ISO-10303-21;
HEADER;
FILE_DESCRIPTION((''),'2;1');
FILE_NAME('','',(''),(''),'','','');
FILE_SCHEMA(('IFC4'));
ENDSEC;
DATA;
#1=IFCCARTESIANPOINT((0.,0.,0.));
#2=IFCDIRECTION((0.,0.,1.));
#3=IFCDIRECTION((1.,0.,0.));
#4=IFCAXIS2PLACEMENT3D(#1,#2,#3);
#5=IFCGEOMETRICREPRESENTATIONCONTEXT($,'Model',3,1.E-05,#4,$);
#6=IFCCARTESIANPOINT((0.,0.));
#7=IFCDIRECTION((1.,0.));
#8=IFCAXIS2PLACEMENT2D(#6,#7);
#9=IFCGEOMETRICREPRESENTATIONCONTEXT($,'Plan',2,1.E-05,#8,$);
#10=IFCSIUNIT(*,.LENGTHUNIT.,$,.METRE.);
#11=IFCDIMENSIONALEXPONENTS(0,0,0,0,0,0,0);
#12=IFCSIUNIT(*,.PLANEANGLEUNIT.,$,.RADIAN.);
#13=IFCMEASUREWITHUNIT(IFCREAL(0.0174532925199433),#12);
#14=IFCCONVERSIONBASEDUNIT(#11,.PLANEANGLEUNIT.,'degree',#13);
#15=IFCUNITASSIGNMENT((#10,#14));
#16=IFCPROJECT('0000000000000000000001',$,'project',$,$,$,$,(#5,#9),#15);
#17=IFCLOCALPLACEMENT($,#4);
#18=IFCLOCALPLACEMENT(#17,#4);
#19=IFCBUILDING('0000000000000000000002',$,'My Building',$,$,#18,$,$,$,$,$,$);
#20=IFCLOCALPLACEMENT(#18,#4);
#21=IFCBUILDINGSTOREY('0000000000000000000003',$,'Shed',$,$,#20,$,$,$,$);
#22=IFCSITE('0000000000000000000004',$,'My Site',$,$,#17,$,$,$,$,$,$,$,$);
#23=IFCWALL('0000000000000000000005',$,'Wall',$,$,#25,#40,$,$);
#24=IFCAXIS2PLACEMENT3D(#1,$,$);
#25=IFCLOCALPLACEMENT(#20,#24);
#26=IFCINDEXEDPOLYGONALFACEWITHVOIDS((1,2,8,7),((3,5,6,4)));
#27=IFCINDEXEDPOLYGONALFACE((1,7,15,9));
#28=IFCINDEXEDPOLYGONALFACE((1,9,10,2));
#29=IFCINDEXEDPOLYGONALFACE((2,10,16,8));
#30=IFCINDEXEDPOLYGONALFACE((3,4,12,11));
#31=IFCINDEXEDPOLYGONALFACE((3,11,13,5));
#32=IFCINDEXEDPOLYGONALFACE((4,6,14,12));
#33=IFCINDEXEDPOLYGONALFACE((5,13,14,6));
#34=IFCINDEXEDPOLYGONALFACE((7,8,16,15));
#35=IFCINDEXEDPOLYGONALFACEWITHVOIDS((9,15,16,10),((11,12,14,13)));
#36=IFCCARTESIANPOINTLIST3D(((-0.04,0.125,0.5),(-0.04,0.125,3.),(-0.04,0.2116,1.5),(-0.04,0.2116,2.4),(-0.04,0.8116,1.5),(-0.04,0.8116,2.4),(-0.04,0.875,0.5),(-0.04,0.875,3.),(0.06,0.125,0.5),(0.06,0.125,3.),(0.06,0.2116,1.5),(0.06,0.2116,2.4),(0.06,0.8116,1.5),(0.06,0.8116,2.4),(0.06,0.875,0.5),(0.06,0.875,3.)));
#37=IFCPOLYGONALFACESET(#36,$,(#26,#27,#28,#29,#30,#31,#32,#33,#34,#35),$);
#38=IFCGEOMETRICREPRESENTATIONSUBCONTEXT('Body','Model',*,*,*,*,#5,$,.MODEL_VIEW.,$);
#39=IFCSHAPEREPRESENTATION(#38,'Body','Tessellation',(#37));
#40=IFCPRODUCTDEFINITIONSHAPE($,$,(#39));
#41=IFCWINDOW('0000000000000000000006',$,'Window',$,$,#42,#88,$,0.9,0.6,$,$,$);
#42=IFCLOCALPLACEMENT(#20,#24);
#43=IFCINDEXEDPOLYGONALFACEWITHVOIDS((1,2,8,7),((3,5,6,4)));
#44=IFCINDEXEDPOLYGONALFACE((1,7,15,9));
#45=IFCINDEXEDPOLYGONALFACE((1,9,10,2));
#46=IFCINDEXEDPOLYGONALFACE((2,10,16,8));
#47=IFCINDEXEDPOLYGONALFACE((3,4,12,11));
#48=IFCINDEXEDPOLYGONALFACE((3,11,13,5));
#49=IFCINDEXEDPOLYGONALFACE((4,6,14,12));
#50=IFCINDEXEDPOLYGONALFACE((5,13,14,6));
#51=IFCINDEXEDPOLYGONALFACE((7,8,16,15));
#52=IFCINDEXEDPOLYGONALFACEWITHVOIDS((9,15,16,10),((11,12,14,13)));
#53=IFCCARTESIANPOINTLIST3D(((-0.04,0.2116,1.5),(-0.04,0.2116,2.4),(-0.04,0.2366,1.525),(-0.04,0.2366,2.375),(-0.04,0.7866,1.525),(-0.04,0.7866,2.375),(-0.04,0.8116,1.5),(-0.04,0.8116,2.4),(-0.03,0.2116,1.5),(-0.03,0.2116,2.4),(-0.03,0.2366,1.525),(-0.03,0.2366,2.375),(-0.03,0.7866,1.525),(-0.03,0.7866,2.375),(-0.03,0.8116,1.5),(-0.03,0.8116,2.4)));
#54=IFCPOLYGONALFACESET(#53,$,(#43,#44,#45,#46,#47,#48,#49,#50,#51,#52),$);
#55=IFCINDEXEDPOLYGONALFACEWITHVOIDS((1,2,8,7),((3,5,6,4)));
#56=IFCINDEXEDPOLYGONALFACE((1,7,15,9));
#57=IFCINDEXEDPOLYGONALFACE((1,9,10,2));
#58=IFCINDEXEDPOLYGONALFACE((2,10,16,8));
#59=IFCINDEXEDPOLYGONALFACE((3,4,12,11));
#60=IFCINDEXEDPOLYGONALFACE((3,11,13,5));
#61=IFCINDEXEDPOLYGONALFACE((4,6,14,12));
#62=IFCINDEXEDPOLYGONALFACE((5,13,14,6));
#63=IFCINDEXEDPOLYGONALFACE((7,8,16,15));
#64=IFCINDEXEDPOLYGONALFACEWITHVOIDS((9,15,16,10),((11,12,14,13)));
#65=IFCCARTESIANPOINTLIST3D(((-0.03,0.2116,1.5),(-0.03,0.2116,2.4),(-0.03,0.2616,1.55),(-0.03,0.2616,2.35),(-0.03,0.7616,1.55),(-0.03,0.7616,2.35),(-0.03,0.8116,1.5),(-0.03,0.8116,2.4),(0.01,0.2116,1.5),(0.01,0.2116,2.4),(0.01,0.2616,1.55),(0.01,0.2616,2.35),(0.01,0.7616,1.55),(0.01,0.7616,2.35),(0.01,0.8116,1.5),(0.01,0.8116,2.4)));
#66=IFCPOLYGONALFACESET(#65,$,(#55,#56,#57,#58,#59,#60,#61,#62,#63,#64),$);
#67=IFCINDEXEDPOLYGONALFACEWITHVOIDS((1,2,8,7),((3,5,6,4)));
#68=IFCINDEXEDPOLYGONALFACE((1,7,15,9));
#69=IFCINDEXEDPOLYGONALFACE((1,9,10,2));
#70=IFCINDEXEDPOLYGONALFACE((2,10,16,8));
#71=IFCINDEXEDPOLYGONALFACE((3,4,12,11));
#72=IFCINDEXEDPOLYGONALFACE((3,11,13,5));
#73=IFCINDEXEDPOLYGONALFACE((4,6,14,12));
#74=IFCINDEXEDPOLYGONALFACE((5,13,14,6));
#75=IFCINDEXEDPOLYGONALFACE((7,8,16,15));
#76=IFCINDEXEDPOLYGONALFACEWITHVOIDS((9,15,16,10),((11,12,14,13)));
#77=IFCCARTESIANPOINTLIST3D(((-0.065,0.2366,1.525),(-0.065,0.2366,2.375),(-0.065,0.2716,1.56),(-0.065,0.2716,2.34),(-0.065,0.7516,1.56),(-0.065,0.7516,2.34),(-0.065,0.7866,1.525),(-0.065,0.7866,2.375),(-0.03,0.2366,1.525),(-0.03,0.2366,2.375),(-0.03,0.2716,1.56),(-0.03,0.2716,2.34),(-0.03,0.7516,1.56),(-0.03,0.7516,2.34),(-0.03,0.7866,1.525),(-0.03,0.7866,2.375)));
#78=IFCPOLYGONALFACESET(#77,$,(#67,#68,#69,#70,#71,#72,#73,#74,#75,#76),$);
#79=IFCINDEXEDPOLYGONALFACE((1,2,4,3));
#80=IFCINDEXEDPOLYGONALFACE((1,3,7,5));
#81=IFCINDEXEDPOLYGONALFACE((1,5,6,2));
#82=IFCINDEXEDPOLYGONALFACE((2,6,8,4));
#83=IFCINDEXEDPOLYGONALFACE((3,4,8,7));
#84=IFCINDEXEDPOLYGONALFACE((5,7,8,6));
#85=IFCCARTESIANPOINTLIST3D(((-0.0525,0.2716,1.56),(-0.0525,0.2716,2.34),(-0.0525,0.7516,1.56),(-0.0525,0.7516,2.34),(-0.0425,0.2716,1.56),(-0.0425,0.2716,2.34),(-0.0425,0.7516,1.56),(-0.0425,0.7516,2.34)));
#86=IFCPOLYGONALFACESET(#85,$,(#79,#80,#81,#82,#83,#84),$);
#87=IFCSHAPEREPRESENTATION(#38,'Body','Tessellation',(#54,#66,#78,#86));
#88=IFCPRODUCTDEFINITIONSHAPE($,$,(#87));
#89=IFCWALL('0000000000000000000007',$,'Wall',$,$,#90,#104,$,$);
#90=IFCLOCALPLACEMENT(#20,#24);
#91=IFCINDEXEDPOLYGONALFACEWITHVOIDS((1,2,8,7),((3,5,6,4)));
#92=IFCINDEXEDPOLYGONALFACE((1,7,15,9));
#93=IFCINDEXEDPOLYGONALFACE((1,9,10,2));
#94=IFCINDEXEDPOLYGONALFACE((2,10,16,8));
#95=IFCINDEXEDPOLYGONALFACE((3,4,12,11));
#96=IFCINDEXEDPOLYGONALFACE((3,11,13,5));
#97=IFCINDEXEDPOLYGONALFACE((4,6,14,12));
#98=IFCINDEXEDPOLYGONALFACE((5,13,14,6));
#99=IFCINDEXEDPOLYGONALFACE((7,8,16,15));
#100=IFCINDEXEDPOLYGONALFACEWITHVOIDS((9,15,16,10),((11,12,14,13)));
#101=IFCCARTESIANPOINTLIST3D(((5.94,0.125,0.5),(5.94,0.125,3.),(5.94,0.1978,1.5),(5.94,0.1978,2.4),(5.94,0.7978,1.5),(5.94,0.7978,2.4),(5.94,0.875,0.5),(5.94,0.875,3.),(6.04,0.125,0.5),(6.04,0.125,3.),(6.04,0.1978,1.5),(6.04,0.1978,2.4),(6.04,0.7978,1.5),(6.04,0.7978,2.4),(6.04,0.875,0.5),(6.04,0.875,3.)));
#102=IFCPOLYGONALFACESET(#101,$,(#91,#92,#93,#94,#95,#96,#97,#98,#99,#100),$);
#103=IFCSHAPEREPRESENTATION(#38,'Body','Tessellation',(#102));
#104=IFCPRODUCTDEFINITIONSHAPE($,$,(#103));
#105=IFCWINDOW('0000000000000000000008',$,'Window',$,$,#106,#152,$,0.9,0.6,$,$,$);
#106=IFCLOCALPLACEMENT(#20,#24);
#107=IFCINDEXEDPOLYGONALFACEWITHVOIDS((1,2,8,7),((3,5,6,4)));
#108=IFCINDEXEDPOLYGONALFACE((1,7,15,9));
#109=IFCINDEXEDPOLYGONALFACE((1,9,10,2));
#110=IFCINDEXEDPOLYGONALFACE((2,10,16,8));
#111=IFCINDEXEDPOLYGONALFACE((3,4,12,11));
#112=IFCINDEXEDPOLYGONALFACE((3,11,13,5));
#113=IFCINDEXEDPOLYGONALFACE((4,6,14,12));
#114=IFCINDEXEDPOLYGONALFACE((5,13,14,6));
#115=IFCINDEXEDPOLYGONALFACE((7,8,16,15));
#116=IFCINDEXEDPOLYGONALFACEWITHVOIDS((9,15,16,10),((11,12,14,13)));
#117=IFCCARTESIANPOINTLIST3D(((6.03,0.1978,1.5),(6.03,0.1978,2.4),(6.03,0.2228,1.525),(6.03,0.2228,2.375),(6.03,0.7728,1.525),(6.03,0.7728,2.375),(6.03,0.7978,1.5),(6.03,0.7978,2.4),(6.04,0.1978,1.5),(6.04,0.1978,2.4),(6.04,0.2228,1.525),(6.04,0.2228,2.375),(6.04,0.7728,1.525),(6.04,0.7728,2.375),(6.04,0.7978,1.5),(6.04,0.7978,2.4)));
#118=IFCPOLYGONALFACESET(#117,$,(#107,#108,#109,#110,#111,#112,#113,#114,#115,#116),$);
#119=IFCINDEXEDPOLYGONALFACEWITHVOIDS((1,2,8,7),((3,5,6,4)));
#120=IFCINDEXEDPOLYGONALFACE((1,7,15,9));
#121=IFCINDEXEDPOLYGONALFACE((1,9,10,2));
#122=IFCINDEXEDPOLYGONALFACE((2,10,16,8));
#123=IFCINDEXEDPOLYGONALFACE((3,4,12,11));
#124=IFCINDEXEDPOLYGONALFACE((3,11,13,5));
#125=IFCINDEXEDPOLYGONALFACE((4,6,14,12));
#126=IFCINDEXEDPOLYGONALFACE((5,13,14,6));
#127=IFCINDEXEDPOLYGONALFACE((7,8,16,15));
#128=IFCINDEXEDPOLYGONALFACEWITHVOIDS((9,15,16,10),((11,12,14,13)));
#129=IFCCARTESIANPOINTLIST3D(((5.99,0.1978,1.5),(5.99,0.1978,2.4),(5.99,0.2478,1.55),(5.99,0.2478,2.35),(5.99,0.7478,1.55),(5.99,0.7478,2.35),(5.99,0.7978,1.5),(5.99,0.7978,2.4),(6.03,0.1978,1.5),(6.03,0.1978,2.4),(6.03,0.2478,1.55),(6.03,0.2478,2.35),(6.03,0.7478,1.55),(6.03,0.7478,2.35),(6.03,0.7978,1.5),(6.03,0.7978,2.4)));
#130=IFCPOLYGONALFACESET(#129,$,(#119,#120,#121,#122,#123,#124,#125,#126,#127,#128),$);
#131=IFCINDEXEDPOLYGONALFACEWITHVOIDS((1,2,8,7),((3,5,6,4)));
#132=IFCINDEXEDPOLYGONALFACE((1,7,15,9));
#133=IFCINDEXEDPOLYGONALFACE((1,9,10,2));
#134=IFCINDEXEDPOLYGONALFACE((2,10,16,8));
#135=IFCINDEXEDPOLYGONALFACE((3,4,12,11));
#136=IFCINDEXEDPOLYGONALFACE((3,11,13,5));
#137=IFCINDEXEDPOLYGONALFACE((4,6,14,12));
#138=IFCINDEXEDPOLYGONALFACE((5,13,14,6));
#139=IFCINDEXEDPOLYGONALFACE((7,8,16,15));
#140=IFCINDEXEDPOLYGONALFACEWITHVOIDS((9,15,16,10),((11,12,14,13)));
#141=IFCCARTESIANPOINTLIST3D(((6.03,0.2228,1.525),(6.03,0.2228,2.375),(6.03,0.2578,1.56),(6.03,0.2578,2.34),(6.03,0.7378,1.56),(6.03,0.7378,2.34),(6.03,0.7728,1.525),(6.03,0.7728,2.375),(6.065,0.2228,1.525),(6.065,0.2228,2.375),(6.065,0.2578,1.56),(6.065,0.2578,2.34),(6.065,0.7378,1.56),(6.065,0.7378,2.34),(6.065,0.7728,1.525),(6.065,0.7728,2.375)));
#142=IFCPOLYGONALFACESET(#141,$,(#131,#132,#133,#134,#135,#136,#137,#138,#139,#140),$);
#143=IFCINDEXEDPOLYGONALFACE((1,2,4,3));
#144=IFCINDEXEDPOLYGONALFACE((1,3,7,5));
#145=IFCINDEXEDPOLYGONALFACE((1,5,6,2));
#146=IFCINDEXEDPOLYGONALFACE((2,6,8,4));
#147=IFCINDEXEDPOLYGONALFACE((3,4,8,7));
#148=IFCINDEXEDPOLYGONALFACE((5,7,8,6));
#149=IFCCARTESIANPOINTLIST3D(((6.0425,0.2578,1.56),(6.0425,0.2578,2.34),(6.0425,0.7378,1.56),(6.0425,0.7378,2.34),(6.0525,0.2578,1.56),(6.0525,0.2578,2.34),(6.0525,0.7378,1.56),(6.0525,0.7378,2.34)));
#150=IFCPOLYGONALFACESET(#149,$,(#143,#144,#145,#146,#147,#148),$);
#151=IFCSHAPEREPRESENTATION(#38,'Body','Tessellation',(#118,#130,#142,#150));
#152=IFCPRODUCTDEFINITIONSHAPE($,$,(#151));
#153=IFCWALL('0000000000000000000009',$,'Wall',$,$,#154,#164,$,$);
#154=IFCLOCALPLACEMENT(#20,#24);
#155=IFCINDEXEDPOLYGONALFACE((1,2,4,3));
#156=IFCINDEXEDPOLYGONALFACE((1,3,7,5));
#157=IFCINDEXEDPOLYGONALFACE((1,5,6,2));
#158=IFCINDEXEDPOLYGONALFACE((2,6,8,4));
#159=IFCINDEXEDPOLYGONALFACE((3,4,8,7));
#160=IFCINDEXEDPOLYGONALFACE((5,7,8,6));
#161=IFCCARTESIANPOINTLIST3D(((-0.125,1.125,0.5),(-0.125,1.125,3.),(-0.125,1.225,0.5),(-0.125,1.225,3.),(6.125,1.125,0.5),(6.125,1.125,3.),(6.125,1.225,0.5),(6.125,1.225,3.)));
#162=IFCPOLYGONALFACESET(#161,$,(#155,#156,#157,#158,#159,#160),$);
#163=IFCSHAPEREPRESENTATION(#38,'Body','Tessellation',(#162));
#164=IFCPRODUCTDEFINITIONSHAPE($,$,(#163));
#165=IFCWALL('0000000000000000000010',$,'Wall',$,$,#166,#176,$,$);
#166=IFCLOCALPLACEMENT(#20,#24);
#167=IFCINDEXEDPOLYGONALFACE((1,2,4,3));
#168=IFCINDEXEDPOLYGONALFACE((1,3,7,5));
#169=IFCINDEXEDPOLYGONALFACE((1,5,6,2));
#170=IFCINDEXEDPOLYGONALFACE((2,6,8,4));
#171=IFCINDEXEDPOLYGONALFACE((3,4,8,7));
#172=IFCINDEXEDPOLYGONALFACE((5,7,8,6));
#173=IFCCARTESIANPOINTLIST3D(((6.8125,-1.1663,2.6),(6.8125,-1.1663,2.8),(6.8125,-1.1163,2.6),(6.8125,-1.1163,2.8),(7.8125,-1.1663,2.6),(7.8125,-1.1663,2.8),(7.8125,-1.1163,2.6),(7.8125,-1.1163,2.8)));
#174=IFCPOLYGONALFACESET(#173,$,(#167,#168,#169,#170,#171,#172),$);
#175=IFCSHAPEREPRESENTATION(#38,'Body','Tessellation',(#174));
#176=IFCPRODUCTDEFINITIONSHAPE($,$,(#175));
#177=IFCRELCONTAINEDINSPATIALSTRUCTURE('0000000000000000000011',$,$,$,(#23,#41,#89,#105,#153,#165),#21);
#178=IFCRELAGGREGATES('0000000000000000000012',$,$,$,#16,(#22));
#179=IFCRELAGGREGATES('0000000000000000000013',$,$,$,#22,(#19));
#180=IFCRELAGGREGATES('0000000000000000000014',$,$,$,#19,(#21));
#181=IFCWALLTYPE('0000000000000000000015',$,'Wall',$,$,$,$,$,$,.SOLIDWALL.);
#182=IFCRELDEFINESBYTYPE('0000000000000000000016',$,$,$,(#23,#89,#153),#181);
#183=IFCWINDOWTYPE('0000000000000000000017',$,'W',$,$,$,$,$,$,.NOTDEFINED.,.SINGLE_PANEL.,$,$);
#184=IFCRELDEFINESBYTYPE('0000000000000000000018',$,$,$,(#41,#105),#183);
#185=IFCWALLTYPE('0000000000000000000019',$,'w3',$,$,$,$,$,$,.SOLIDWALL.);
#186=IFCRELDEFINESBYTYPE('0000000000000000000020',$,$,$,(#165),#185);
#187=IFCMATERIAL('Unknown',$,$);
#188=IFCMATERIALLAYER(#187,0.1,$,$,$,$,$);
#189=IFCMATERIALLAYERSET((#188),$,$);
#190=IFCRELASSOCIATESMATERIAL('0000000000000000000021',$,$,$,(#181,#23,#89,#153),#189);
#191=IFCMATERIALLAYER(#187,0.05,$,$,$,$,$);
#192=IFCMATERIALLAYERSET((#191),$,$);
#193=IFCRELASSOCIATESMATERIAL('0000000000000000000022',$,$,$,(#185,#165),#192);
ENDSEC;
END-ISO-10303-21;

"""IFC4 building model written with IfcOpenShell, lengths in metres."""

from ifc_helpers import new_model, entity, si_unit, converted_unit, frame, origin_with_axes, origin_2d_with_axis, place, context, subcontext, project, spatial, line, indexed_curve, outline, extrude, shape, source, transform, mapped, material, layer, layer_set, layer_usage, type_object, type_shapes, element, fill, save


model = new_model("IFC4")

# Units and contexts
model_context = context("Model", 3, precision=1e-05, world=origin_with_axes())
plan_context = context("Plan", 2, precision=1e-05, world=origin_2d_with_axis())
body_context_1 = subcontext(model_context, "Body", "Model", "MODEL_VIEW")
body_context_2 = subcontext(plan_context, "Body", "Plan", "PLAN_VIEW")
ifc_project = project(units=[si_unit("LENGTHUNIT", "METRE"), converted_unit("PLANEANGLEUNIT", "degree", entity("IfcReal", 0.0174532925199433), si_unit("PLANEANGLEUNIT", "RADIAN"), dimensions=[0, 0, 0, 0, 0, 0, 0])], contexts=[model_context, plan_context])

# Site, building, storey
site_placement = place(None, origin_with_axes())
site = spatial("IfcSite", under=ifc_project, at=site_placement, Name="My Site")
building_placement = place(site_placement, origin_with_axes())
building = spatial("IfcBuilding", under=site, at=building_placement, Name="My Building")
storey_placement = place(building_placement, origin_with_axes())
storey = spatial("IfcBuildingStorey", under=building, at=storey_placement, Name="Shed")

# Shared definitions
ifc_material = material(Name="Unknown")

# Walls, openings, windows
ifc_layer_1 = layer(ifc_material, 0.1)
ifc_layer_set_1 = layer_set([ifc_layer_1])
ifc_layer_usage_1 = layer_usage(ifc_layer_set_1, "AXIS2", "POSITIVE", 0.0)
wall_type_1 = type_object("IfcWallType", Name="Wall", PredefinedType="SOLIDWALL", material=ifc_layer_set_1)
wall_1_placement = place(storey_placement, frame((0.06, 0.125, 0.5), z_axis=(0.0, 0.0, 1.0), x_axis=(0.0, 1.0, 0.0)))
wall_1 = element("IfcWall", 1, at=wall_1_placement, inside=storey, type_object=wall_type_1, material=ifc_layer_usage_1, Name="Wall", context=body_context_1, shape_type="SweptSolid", body=[
    extrude(outline(indexed_curve([(0.0, 0.0), (0.0, 0.1), (0.75, 0.1), (0.75, 0.0)], segments=[line(1, 2, 3, 4, 1)])), origin_with_axes(), (0.0, 0.0, 1.0), 2.5),
])
shared_shape_1 = source(origin_with_axes(), body_context_1, "Body", "SweptSolid", [
    extrude(outline(indexed_curve([(0.0, 0.0), (0.6, 0.0), (0.6, 0.9), (0.0, 0.9)], segments=[line(1, 2, 3, 4, 1)])), frame((0.0, -0.6, 0.0), z_axis=(0.0, -1.0, 0.0), x_axis=(1.0, 0.0, 0.0)), (0.0, 0.0, -1.0), 1.2),
])
opening_1_placement = place(wall_1_placement, frame((0.0866, 0.0, 1.0), z_axis=(0.0, 0.0, 1.0), x_axis=(1.0, 0.0, 0.0)))
opening_1 = element("IfcOpeningElement", 2, at=opening_1_placement, cuts=wall_1, PredefinedType="OPENING", context=body_context_1, shape_type="MappedRepresentation", body=[
    mapped(shared_shape_1, transform((0.0, 0.0, 0.0), x_axis=(1.0, 0.0, 0.0), y_axis=(0.0, 1.0, 0.0), z_axis=(0.0, 0.0, 1.0), scale=1.0)),
])
window_type = type_object("IfcWindowType", Name="W", PartitioningType="SINGLE_PANEL", PredefinedType="NOTDEFINED")
shared_shape_2 = source(origin_with_axes(), body_context_1, "Body", "SweptSolid", [
    extrude(outline(indexed_curve([(0.0, 0.0), (0.6, 0.0), (0.6, 0.9), (0.0, 0.9)], segments=[line(1, 2, 3, 4, 1)]), holes=[indexed_curve([(0.025, 0.025), (0.575, 0.025), (0.575, 0.875), (0.025, 0.875)], segments=[line(1, 2, 3, 4, 1)])]), frame((0.0, 0.09, 0.0), z_axis=(0.0, -1.0, 0.0), x_axis=(1.0, 0.0, 0.0)), (0.0, 0.0, -1.0), 0.01),
    extrude(outline(indexed_curve([(0.0, 0.0), (0.6, 0.0), (0.6, 0.9), (0.0, 0.9)], segments=[line(1, 2, 3, 4, 1)]), holes=[indexed_curve([(0.05, 0.05), (0.55, 0.05), (0.55, 0.85), (0.05, 0.85)], segments=[line(1, 2, 3, 4, 1)])]), frame((0.0, 0.05, 0.0), z_axis=(0.0, -1.0, 0.0), x_axis=(1.0, 0.0, 0.0)), (0.0, 0.0, -1.0), 0.04),
    extrude(outline(indexed_curve([(0.0, 0.0), (0.55, 0.0), (0.55, 0.85), (0.0, 0.85)], segments=[line(1, 2, 3, 4, 1)]), holes=[indexed_curve([(0.035, 0.035), (0.515, 0.035), (0.515, 0.815), (0.035, 0.815)], segments=[line(1, 2, 3, 4, 1)])]), frame((0.025, 0.09, 0.025), z_axis=(0.0, -1.0, 0.0), x_axis=(1.0, 0.0, 0.0)), (0.0, 0.0, -1.0), 0.035),
    extrude(outline(indexed_curve([(0.035, 0.035), (0.515, 0.035), (0.515, 0.815), (0.035, 0.815)], segments=[line(1, 2, 3, 4, 1)])), frame((0.025, 0.1025, 0.025), z_axis=(0.0, -1.0, 0.0), x_axis=(1.0, 0.0, 0.0)), (0.0, 0.0, -1.0), 0.01),
])
shared_shape_3 = source(origin_with_axes(), body_context_2, "Body", "Curve2D", [
    entity("IfcIndexedPolyCurve", entity("IfcCartesianPointList2D", [[0.05, 0.05], [0.55, 0.05]])),
    entity("IfcIndexedPolyCurve", entity("IfcCartesianPointList2D", [[0.0, 0.1], [0.025, 0.1], [0.025, 0.09], [0.05, 0.09], [0.05, 0.05], [0.0, 0.05]]), [entity("IfcLineIndex", [1, 2, 3, 4, 5, 6, 1])]),
    entity("IfcIndexedPolyCurve", entity("IfcCartesianPointList2D", [[0.6, 0.1], [0.575, 0.1], [0.575, 0.09], [0.55, 0.09], [0.55, 0.05], [0.6, 0.05]]), [entity("IfcLineIndex", [1, 2, 3, 4, 5, 6, 1])]),
    entity("IfcIndexedPolyCurve", entity("IfcCartesianPointList2D", [[0.025, 0.09], [0.06, 0.09], [0.06, 0.125], [0.025, 0.125]]), [entity("IfcLineIndex", [1, 2, 3, 4, 1])]),
    entity("IfcIndexedPolyCurve", entity("IfcCartesianPointList2D", [[0.575, 0.09], [0.54, 0.09], [0.54, 0.125], [0.575, 0.125]]), [entity("IfcLineIndex", [1, 2, 3, 4, 1])]),
    entity("IfcIndexedPolyCurve", entity("IfcCartesianPointList2D", [[0.06, 0.09], [0.54, 0.09]])),
    entity("IfcIndexedPolyCurve", entity("IfcCartesianPointList2D", [[0.06, 0.125], [0.54, 0.125]])),
    entity("IfcIndexedPolyCurve", entity("IfcCartesianPointList2D", [[0.06, 0.1075], [0.54, 0.1075]])),
])
type_shapes(window_type, [shared_shape_2, shared_shape_3])
window_1_placement = place(opening_1_placement, origin_with_axes())
window_1 = element("IfcWindow", 3, at=window_1_placement, inside=storey, type_object=window_type, Name="Window", OverallHeight=0.9, OverallWidth=0.6, shapes=[
    shape(body_context_1, "Body", "MappedRepresentation", [mapped(shared_shape_2, transform((0.0, 0.0, 0.0), x_axis=(1.0, 0.0, 0.0), y_axis=(0.0, 1.0, 0.0), z_axis=(0.0, 0.0, 1.0), scale=1.0))]),
    shape(body_context_2, "Body", "MappedRepresentation", [mapped(shared_shape_3, transform((0.0, 0.0, 0.0), x_axis=(1.0, 0.0, 0.0), y_axis=(0.0, 1.0, 0.0), z_axis=(0.0, 0.0, 1.0), scale=1.0))]),
])
fill(opening_1, window_1)
ifc_layer_usage_2 = layer_usage(ifc_layer_set_1, "AXIS2", "POSITIVE", 0.0)
wall_2_placement = place(storey_placement, frame((5.94, 0.875, 0.5), z_axis=(0.0, 0.0, 1.0), x_axis=(0.0, -1.0, 0.0)))
wall_2 = element("IfcWall", 4, at=wall_2_placement, inside=storey, type_object=wall_type_1, material=ifc_layer_usage_2, Name="Wall", context=body_context_1, shape_type="SweptSolid", body=[
    extrude(outline(indexed_curve([(0.0, 0.0), (0.0, 0.1), (0.75, 0.1), (0.75, 0.0)], segments=[line(1, 2, 3, 4, 1)])), origin_with_axes(), (0.0, 0.0, 1.0), 2.5),
])
opening_2_placement = place(wall_2_placement, frame((0.0772, 0.0, 1.0), z_axis=(0.0, 0.0, 1.0), x_axis=(1.0, 0.0, 0.0)))
opening_2 = element("IfcOpeningElement", 5, at=opening_2_placement, cuts=wall_2, PredefinedType="OPENING", context=body_context_1, shape_type="MappedRepresentation", body=[
    mapped(shared_shape_1, transform((0.0, 0.0, 0.0), x_axis=(1.0, 0.0, 0.0), y_axis=(0.0, 1.0, 0.0), z_axis=(0.0, 0.0, 1.0), scale=1.0)),
])
window_2_placement = place(opening_2_placement, frame((0.0, 0.0, 0.0), z_axis=(0.0, 0.0, 1.0), x_axis=(1.0, 0.0, 0.0)))
window_2 = element("IfcWindow", 6, at=window_2_placement, inside=storey, type_object=window_type, Name="Window", OverallHeight=0.9, OverallWidth=0.6, shapes=[
    shape(body_context_1, "Body", "MappedRepresentation", [mapped(shared_shape_2, transform((0.0, 0.0, 0.0), x_axis=(1.0, 0.0, 0.0), y_axis=(0.0, 1.0, 0.0), z_axis=(0.0, 0.0, 1.0), scale=1.0))]),
    shape(body_context_2, "Body", "MappedRepresentation", [mapped(shared_shape_3, transform((0.0, 0.0, 0.0), x_axis=(1.0, 0.0, 0.0), y_axis=(0.0, 1.0, 0.0), z_axis=(0.0, 0.0, 1.0), scale=1.0))]),
])
fill(opening_2, window_2)

# Walls
ifc_layer_usage_3 = layer_usage(ifc_layer_set_1, "AXIS2", "POSITIVE", 0.0)
wall_3_placement = place(storey_placement, frame((-0.125, 1.125, 0.5), z_axis=(0.0, 0.0, 1.0), x_axis=(1.0, 0.0, 0.0)))
element("IfcWall", 7, at=wall_3_placement, inside=storey, type_object=wall_type_1, material=ifc_layer_usage_3, Name="Wall", context=body_context_1, shape_type="SweptSolid", body=[
    extrude(outline(indexed_curve([(0.0, 0.0), (0.0, 0.1), (6.25, 0.1), (6.25, 0.0)], segments=[line(1, 2, 3, 4, 1)])), origin_with_axes(), (0.0, 0.0, 1.0), 2.5),
])
ifc_layer_2 = layer(ifc_material, 0.05)
ifc_layer_set_2 = layer_set([ifc_layer_2])
ifc_layer_usage_4 = layer_usage(ifc_layer_set_2, "AXIS2", "POSITIVE", 0.0)
wall_type_2 = type_object("IfcWallType", Name="w3", PredefinedType="SOLIDWALL", material=ifc_layer_set_2)
wall_4_placement = place(storey_placement, frame((6.8125, -1.1663, 2.6), z_axis=(0.0, 0.0, 1.0), x_axis=(1.0, 0.0, 0.0)))
element("IfcWall", 8, at=wall_4_placement, inside=storey, type_object=wall_type_2, material=ifc_layer_usage_4, Name="Wall", context=body_context_1, shape_type="SweptSolid", body=[
    extrude(outline(indexed_curve([(0.0, 0.0), (0.0, 0.05), (1.0, 0.05), (1.0, 0.0)], segments=[line(1, 2, 3, 4, 1)])), origin_with_axes(), (0.0, 0.0, 1.0), 0.2),
])

save(model, "model.ifc")
